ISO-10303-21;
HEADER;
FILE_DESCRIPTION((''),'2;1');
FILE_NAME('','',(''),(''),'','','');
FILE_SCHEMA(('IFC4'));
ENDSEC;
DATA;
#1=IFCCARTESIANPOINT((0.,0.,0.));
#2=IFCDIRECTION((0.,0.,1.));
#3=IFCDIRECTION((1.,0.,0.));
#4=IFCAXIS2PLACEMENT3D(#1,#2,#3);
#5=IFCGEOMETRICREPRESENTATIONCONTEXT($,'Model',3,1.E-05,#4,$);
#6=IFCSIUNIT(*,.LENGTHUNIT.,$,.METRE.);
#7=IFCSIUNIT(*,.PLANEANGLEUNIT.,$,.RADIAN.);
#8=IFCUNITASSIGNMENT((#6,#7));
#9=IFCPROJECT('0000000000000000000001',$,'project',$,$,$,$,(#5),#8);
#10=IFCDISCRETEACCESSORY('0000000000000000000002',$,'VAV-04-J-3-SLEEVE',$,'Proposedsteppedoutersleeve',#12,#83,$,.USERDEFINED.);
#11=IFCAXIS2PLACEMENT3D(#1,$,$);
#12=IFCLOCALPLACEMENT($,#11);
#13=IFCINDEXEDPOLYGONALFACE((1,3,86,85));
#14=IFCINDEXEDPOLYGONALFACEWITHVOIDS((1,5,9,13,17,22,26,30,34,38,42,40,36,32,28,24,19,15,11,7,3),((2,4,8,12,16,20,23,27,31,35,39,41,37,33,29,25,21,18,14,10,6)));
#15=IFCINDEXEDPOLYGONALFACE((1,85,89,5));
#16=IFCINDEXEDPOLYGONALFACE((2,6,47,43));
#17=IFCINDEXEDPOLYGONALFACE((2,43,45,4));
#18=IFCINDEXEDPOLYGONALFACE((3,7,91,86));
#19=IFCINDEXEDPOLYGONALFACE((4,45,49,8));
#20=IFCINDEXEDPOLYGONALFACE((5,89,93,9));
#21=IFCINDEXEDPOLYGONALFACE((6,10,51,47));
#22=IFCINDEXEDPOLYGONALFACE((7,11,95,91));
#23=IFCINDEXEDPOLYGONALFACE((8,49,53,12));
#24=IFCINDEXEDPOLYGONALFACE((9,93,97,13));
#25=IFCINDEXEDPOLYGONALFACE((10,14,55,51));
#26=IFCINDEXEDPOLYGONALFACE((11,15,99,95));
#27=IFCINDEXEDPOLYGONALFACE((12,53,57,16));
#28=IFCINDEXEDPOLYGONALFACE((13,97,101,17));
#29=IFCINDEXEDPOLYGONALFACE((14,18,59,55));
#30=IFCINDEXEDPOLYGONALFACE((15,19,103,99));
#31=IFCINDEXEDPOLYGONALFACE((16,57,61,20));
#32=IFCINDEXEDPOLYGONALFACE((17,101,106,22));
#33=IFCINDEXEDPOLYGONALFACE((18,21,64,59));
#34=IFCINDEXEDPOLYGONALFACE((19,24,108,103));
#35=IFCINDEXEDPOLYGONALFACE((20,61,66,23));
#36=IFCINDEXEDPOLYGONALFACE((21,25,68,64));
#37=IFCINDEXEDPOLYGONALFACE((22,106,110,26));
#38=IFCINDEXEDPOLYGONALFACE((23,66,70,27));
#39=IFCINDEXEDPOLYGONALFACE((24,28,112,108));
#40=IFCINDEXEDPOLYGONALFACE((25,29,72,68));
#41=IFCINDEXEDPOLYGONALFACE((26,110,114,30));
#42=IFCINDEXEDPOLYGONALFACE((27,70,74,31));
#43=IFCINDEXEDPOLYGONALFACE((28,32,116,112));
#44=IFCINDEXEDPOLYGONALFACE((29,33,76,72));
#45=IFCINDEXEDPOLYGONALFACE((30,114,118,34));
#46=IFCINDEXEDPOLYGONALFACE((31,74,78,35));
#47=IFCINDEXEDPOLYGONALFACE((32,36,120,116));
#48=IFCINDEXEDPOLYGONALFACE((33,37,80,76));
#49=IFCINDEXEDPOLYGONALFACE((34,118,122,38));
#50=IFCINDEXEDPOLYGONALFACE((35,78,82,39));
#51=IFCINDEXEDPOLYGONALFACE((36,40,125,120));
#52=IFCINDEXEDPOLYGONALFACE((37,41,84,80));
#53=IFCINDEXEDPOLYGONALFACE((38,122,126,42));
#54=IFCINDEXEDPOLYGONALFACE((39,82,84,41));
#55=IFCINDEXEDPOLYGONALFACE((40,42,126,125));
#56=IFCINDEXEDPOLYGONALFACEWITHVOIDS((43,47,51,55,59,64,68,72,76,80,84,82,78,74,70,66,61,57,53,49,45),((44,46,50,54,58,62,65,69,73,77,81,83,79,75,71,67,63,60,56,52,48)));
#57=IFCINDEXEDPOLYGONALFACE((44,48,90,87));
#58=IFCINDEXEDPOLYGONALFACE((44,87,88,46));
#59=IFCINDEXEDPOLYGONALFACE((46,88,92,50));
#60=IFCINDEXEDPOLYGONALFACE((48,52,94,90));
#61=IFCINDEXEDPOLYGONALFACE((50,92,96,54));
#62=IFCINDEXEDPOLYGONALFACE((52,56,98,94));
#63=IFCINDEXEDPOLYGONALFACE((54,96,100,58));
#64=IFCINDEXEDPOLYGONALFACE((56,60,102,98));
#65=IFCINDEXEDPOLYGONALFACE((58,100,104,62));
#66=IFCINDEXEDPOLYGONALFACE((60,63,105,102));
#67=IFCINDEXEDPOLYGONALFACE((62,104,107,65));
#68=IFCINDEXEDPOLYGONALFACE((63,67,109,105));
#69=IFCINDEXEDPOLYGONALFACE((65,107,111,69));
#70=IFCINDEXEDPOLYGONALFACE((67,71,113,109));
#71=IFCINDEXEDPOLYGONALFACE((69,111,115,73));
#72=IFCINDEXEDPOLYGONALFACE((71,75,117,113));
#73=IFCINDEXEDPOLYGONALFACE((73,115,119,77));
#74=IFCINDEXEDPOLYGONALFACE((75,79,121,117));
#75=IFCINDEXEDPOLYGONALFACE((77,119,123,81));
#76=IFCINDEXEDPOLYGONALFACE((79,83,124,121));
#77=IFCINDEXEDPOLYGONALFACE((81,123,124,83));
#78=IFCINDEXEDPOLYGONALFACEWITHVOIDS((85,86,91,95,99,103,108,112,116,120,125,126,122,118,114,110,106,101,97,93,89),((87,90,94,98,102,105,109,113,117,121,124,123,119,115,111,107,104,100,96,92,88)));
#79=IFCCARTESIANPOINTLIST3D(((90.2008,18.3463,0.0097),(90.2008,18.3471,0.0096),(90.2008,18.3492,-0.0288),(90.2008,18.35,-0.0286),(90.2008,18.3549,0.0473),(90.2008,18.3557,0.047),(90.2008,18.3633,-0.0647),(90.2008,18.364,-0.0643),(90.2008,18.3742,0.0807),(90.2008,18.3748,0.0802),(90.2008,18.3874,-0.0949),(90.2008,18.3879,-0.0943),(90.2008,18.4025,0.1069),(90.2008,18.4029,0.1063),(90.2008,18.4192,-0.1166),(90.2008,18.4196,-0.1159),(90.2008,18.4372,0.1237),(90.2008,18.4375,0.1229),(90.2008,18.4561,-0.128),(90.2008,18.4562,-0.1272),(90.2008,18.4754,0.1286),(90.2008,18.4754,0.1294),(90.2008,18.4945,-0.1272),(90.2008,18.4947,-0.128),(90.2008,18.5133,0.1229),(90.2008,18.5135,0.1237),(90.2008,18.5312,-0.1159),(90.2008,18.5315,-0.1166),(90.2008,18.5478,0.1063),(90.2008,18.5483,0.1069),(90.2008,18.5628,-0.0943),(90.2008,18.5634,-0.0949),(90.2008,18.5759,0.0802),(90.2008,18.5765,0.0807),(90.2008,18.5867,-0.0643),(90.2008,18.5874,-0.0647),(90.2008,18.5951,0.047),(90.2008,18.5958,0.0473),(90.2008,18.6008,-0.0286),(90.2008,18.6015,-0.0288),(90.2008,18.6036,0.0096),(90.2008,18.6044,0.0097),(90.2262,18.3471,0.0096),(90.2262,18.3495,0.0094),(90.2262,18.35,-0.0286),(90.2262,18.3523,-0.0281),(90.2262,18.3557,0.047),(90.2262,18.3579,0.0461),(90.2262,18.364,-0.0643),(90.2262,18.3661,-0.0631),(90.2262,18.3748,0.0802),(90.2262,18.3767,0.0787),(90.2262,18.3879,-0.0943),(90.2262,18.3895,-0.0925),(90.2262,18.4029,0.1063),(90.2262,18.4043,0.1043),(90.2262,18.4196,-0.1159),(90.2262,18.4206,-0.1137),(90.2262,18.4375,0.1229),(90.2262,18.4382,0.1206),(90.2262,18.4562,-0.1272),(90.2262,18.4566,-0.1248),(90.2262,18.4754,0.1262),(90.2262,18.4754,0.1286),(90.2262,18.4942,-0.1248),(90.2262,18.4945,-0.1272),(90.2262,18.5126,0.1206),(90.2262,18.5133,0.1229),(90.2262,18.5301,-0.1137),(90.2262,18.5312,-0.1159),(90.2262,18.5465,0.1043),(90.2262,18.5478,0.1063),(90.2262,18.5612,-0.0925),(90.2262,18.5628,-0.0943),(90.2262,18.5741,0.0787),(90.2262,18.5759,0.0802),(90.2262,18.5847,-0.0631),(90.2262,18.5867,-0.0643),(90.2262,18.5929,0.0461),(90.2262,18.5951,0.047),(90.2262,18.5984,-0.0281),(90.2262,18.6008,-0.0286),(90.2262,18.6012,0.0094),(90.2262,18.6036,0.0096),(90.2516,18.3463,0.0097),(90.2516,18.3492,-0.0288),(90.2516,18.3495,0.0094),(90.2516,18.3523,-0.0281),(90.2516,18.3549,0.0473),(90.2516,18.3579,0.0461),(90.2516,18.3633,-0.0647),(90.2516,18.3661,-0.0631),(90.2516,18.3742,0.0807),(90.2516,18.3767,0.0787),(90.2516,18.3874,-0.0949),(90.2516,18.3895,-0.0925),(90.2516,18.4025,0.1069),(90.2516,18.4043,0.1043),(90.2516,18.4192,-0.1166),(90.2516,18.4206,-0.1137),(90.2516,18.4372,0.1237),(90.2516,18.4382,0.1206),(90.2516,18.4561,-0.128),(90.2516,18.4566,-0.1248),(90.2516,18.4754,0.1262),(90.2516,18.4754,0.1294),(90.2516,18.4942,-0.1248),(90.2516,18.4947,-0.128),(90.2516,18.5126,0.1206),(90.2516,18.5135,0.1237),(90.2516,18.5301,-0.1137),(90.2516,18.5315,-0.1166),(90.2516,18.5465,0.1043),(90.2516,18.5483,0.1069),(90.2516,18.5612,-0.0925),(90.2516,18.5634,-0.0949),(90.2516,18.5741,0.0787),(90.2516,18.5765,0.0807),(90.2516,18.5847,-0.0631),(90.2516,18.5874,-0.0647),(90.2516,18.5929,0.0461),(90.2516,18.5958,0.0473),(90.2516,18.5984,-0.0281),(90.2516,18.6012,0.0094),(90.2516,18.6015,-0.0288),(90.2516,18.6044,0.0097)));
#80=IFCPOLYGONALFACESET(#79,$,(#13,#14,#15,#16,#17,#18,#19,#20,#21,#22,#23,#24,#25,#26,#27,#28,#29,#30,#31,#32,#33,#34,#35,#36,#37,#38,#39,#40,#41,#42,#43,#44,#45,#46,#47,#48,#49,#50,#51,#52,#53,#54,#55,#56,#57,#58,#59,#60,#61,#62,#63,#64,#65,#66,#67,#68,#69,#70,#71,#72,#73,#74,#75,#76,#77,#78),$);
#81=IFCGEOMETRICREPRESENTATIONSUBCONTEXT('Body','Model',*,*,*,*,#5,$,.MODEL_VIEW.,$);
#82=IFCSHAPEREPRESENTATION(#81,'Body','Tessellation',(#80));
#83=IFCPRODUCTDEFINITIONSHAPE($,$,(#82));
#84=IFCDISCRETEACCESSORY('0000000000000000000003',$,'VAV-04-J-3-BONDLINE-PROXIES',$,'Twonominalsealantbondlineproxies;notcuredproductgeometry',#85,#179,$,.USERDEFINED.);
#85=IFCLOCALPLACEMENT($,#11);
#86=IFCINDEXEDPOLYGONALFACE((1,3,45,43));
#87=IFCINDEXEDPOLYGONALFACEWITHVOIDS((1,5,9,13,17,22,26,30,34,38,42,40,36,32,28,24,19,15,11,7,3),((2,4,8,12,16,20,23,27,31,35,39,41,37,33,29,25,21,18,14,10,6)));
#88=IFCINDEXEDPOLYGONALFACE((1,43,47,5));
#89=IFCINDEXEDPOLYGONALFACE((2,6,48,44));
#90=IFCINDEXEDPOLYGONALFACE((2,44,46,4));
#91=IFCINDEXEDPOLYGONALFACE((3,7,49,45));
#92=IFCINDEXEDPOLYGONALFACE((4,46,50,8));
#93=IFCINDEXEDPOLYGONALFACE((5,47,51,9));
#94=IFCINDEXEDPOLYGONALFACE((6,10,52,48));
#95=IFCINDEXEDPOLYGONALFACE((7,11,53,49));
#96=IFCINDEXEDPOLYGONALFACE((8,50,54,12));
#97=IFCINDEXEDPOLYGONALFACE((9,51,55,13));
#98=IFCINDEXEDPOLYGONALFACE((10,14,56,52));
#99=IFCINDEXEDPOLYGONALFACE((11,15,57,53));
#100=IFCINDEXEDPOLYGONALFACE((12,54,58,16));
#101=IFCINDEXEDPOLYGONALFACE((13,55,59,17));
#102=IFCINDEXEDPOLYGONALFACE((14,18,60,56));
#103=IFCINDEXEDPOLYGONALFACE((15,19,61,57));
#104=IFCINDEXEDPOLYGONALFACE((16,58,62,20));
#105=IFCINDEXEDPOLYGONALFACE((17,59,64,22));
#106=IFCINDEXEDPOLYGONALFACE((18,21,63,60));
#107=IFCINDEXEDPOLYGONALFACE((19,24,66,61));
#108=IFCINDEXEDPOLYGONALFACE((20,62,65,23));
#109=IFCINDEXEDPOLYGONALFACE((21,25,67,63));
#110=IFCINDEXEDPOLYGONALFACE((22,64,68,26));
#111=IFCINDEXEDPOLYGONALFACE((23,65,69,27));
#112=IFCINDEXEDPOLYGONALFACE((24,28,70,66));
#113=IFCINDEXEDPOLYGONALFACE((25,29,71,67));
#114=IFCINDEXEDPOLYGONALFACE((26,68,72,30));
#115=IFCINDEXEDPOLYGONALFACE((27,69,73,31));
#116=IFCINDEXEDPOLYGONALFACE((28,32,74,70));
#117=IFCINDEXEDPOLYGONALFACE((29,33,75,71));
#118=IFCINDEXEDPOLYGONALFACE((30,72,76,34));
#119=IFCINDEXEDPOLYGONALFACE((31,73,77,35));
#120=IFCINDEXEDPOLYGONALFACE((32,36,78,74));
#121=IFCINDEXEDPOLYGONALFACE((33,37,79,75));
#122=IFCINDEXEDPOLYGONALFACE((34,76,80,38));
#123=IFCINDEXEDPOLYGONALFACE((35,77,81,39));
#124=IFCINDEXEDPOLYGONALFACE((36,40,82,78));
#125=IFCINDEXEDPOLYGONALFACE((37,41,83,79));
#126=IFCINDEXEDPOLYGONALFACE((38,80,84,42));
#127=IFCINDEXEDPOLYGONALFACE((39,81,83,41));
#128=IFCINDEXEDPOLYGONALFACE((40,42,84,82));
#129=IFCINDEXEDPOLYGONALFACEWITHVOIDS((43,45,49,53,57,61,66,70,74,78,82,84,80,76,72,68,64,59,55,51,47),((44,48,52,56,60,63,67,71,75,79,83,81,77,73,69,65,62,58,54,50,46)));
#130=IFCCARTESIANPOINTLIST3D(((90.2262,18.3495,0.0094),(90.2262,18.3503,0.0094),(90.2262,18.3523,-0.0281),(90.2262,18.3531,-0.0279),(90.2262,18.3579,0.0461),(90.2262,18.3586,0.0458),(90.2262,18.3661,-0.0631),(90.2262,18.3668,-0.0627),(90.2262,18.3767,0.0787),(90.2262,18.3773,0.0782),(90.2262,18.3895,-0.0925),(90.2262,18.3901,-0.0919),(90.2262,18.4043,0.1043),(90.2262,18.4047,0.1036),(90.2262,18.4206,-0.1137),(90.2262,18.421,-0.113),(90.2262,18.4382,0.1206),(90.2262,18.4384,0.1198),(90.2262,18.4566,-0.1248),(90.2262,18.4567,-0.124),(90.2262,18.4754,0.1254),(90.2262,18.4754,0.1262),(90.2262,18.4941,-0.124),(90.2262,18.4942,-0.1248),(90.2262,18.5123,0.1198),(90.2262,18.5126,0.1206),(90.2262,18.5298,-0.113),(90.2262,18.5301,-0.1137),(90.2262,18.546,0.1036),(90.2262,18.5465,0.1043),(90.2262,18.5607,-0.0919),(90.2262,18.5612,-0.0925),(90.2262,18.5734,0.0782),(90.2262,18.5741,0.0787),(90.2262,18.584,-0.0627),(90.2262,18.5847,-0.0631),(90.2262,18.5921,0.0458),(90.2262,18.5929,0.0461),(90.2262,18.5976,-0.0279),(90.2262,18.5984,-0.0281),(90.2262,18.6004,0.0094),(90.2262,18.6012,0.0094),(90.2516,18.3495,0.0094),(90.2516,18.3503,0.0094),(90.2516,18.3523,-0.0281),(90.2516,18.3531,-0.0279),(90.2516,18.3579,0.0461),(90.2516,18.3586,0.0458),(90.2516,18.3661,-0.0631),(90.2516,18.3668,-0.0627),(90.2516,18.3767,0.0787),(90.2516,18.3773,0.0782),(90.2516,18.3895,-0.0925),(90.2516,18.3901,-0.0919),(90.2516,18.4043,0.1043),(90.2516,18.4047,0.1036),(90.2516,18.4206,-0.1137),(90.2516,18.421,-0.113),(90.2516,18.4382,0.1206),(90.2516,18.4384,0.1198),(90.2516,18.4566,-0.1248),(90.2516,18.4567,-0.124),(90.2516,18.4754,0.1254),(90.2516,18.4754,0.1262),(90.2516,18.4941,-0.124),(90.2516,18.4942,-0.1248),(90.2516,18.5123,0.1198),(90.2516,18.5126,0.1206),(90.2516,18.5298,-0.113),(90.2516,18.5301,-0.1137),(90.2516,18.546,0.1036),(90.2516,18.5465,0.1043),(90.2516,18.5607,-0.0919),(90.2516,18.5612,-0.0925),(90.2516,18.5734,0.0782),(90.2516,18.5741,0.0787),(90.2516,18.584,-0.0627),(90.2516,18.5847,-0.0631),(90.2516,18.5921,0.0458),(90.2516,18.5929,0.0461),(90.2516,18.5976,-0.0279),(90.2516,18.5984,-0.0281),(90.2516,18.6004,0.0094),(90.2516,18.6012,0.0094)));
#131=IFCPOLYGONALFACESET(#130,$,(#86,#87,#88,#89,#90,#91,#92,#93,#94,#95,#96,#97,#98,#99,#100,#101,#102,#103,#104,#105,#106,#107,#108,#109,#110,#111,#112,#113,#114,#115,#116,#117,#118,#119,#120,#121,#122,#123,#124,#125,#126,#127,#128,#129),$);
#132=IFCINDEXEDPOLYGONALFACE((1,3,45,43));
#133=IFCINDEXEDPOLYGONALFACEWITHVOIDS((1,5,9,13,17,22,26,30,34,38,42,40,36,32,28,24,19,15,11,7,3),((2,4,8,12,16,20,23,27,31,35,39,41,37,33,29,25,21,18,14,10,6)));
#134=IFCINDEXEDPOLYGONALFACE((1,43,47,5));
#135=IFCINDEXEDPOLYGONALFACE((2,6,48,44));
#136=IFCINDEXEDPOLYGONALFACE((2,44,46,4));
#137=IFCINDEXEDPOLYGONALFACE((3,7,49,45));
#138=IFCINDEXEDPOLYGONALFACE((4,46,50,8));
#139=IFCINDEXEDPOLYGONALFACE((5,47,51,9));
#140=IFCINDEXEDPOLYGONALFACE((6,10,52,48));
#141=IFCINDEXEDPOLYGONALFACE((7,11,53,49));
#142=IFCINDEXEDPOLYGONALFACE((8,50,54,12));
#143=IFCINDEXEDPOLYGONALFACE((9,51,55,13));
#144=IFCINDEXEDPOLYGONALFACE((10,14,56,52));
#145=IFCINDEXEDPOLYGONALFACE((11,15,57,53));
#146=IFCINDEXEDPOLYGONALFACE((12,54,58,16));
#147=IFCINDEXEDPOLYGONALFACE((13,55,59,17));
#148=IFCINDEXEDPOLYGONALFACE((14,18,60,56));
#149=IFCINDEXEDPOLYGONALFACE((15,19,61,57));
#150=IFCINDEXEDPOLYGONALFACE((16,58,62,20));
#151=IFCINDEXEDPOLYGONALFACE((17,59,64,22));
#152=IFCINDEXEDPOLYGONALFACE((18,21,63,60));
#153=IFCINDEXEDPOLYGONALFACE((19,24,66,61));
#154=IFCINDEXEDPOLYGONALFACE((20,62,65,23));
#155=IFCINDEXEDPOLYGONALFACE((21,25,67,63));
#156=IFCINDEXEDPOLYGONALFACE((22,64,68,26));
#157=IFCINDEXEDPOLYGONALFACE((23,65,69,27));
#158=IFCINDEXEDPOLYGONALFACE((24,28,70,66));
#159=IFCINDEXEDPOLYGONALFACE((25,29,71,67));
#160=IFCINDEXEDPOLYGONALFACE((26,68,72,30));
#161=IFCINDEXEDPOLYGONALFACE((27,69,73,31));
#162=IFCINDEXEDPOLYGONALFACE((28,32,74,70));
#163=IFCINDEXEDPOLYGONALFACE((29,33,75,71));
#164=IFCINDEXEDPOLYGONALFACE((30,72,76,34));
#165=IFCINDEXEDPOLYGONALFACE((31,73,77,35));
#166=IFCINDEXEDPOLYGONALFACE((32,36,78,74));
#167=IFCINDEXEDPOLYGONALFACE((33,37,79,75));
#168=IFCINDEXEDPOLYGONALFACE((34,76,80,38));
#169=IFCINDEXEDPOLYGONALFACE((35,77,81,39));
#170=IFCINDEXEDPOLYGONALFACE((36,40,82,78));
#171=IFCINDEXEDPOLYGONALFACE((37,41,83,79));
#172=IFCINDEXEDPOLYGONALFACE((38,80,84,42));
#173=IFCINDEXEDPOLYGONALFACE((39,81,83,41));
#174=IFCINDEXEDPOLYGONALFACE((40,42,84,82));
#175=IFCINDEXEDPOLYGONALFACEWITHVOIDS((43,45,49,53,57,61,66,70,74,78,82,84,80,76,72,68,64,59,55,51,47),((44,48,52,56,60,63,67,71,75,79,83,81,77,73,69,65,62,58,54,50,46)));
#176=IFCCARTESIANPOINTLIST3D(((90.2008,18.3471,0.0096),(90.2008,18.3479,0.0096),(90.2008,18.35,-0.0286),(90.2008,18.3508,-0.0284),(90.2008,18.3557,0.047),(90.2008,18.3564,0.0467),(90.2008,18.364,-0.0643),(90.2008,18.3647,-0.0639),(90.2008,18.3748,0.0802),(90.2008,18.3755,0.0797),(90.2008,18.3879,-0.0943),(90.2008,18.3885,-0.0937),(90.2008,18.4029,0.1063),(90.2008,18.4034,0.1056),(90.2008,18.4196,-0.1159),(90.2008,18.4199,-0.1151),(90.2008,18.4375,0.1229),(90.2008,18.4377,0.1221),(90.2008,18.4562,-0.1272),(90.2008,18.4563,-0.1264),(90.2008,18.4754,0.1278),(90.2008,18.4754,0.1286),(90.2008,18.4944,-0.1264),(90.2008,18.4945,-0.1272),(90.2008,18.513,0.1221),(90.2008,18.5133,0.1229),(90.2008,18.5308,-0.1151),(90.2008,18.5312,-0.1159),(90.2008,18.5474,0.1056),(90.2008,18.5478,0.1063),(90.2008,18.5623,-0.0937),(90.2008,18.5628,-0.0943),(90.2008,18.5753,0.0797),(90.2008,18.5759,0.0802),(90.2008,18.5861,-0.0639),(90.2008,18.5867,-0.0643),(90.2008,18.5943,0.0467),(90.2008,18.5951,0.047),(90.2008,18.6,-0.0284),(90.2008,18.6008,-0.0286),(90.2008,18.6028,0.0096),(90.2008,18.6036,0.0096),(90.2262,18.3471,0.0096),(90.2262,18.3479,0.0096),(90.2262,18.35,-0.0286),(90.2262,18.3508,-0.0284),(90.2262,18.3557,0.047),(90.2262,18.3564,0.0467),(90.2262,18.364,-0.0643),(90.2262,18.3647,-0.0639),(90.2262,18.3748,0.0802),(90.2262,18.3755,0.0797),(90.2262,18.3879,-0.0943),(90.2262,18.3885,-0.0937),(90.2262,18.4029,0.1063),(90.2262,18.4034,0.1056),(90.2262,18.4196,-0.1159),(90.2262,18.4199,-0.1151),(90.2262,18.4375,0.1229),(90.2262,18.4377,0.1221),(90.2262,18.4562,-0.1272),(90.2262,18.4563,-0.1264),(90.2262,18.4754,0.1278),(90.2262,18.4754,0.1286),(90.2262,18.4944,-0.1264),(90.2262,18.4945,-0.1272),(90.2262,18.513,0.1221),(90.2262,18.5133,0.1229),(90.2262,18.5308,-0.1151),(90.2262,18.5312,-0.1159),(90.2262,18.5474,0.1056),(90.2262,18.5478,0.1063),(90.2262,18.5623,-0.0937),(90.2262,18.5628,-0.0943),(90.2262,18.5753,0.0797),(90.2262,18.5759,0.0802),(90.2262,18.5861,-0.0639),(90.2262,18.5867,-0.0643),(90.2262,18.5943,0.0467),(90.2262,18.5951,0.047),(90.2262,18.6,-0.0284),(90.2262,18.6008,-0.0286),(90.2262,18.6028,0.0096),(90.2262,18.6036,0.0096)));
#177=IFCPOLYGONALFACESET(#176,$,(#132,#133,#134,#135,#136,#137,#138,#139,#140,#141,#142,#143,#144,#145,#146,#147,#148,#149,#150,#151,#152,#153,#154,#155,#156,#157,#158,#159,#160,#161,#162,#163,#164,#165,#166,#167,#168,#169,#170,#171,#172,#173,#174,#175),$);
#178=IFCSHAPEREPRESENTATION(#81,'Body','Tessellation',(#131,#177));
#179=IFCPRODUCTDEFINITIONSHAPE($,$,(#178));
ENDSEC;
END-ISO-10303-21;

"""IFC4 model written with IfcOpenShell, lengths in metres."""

from ifc_helpers import new_model, entity, si_unit, frame, origin_with_axes, place, context, subcontext, project, element, save


model = new_model("IFC4")

# Units and contexts
model_context = context("Model", 3, precision=1e-05, world=origin_with_axes())
body_context = subcontext(model_context, "Body", "Model", "MODEL_VIEW")
ifc_project = project(units=[si_unit("LENGTHUNIT", "METRE"), si_unit("PLANEANGLEUNIT", "RADIAN")], contexts=[model_context])

# Discrete accessories
discrete_accessory_1_placement = place(None, frame((90.2262, 18.4754, 0.0), z_axis=(0.0, -1.0, 0.0), x_axis=(0.0, 0.0, 1.0)))
element("IfcDiscreteAccessory", 1, at=discrete_accessory_1_placement, Name="VAV-04-J-3-SLEEVE", ObjectType="Proposedsteppedoutersleeve", PredefinedType="USERDEFINED", context=body_context, shape_type="SweptSolid", body=[
    entity("IfcRevolvedAreaSolid", entity("IfcArbitraryClosedProfileDef", "AREA", None, entity("IfcPolyline", [entity("IfcCartesianPoint", [0.1262, -0.0254]), entity("IfcCartesianPoint", [0.1294, -0.0254]), entity("IfcCartesianPoint", [0.1294, 0.0254]), entity("IfcCartesianPoint", [0.1286, 0.0254]), entity("IfcCartesianPoint", [0.1286, 0.0]), entity("IfcCartesianPoint", [0.1262, 0.0]), entity("IfcCartesianPoint", [0.1262, -0.0254])])), entity("IfcAxis2Placement3D", entity("IfcCartesianPoint", [0.0, 0.0, 0.0])), entity("IfcAxis1Placement", entity("IfcCartesianPoint", [0.0, 0.0, 0.0]), entity("IfcDirection", [0.0, 1.0, 0.0])), 6.283185),
])
discrete_accessory_2_placement = place(None, frame((90.2262, 18.4754, 0.0), z_axis=(0.0, -1.0, 0.0), x_axis=(0.0, 0.0, 1.0)))
element("IfcDiscreteAccessory", 2, at=discrete_accessory_2_placement, Name="VAV-04-J-3-BONDLINE-PROXIES", ObjectType="Twonominalsealantbondlineproxies;notcuredproductgeometry", PredefinedType="USERDEFINED", context=body_context, shape_type="SweptSolid", body=[
    entity("IfcRevolvedAreaSolid", entity("IfcArbitraryClosedProfileDef", "AREA", None, entity("IfcPolyline", [entity("IfcCartesianPoint", [0.1254, -0.0254]), entity("IfcCartesianPoint", [0.1262, -0.0254]), entity("IfcCartesianPoint", [0.1262, 0.0]), entity("IfcCartesianPoint", [0.1254, 0.0]), entity("IfcCartesianPoint", [0.1254, -0.0254])])), entity("IfcAxis2Placement3D", entity("IfcCartesianPoint", [0.0, 0.0, 0.0])), entity("IfcAxis1Placement", entity("IfcCartesianPoint", [0.0, 0.0, 0.0]), entity("IfcDirection", [0.0, 1.0, 0.0])), 6.283185),
    entity("IfcRevolvedAreaSolid", entity("IfcArbitraryClosedProfileDef", "AREA", None, entity("IfcPolyline", [entity("IfcCartesianPoint", [0.1278, 0.0]), entity("IfcCartesianPoint", [0.1286, 0.0]), entity("IfcCartesianPoint", [0.1286, 0.0254]), entity("IfcCartesianPoint", [0.1278, 0.0254]), entity("IfcCartesianPoint", [0.1278, 0.0])])), entity("IfcAxis2Placement3D", entity("IfcCartesianPoint", [0.0, 0.0, 0.0])), entity("IfcAxis1Placement", entity("IfcCartesianPoint", [0.0, 0.0, 0.0]), entity("IfcDirection", [0.0, 1.0, 0.0])), 6.283185),
])

save(model, "model.ifc")
